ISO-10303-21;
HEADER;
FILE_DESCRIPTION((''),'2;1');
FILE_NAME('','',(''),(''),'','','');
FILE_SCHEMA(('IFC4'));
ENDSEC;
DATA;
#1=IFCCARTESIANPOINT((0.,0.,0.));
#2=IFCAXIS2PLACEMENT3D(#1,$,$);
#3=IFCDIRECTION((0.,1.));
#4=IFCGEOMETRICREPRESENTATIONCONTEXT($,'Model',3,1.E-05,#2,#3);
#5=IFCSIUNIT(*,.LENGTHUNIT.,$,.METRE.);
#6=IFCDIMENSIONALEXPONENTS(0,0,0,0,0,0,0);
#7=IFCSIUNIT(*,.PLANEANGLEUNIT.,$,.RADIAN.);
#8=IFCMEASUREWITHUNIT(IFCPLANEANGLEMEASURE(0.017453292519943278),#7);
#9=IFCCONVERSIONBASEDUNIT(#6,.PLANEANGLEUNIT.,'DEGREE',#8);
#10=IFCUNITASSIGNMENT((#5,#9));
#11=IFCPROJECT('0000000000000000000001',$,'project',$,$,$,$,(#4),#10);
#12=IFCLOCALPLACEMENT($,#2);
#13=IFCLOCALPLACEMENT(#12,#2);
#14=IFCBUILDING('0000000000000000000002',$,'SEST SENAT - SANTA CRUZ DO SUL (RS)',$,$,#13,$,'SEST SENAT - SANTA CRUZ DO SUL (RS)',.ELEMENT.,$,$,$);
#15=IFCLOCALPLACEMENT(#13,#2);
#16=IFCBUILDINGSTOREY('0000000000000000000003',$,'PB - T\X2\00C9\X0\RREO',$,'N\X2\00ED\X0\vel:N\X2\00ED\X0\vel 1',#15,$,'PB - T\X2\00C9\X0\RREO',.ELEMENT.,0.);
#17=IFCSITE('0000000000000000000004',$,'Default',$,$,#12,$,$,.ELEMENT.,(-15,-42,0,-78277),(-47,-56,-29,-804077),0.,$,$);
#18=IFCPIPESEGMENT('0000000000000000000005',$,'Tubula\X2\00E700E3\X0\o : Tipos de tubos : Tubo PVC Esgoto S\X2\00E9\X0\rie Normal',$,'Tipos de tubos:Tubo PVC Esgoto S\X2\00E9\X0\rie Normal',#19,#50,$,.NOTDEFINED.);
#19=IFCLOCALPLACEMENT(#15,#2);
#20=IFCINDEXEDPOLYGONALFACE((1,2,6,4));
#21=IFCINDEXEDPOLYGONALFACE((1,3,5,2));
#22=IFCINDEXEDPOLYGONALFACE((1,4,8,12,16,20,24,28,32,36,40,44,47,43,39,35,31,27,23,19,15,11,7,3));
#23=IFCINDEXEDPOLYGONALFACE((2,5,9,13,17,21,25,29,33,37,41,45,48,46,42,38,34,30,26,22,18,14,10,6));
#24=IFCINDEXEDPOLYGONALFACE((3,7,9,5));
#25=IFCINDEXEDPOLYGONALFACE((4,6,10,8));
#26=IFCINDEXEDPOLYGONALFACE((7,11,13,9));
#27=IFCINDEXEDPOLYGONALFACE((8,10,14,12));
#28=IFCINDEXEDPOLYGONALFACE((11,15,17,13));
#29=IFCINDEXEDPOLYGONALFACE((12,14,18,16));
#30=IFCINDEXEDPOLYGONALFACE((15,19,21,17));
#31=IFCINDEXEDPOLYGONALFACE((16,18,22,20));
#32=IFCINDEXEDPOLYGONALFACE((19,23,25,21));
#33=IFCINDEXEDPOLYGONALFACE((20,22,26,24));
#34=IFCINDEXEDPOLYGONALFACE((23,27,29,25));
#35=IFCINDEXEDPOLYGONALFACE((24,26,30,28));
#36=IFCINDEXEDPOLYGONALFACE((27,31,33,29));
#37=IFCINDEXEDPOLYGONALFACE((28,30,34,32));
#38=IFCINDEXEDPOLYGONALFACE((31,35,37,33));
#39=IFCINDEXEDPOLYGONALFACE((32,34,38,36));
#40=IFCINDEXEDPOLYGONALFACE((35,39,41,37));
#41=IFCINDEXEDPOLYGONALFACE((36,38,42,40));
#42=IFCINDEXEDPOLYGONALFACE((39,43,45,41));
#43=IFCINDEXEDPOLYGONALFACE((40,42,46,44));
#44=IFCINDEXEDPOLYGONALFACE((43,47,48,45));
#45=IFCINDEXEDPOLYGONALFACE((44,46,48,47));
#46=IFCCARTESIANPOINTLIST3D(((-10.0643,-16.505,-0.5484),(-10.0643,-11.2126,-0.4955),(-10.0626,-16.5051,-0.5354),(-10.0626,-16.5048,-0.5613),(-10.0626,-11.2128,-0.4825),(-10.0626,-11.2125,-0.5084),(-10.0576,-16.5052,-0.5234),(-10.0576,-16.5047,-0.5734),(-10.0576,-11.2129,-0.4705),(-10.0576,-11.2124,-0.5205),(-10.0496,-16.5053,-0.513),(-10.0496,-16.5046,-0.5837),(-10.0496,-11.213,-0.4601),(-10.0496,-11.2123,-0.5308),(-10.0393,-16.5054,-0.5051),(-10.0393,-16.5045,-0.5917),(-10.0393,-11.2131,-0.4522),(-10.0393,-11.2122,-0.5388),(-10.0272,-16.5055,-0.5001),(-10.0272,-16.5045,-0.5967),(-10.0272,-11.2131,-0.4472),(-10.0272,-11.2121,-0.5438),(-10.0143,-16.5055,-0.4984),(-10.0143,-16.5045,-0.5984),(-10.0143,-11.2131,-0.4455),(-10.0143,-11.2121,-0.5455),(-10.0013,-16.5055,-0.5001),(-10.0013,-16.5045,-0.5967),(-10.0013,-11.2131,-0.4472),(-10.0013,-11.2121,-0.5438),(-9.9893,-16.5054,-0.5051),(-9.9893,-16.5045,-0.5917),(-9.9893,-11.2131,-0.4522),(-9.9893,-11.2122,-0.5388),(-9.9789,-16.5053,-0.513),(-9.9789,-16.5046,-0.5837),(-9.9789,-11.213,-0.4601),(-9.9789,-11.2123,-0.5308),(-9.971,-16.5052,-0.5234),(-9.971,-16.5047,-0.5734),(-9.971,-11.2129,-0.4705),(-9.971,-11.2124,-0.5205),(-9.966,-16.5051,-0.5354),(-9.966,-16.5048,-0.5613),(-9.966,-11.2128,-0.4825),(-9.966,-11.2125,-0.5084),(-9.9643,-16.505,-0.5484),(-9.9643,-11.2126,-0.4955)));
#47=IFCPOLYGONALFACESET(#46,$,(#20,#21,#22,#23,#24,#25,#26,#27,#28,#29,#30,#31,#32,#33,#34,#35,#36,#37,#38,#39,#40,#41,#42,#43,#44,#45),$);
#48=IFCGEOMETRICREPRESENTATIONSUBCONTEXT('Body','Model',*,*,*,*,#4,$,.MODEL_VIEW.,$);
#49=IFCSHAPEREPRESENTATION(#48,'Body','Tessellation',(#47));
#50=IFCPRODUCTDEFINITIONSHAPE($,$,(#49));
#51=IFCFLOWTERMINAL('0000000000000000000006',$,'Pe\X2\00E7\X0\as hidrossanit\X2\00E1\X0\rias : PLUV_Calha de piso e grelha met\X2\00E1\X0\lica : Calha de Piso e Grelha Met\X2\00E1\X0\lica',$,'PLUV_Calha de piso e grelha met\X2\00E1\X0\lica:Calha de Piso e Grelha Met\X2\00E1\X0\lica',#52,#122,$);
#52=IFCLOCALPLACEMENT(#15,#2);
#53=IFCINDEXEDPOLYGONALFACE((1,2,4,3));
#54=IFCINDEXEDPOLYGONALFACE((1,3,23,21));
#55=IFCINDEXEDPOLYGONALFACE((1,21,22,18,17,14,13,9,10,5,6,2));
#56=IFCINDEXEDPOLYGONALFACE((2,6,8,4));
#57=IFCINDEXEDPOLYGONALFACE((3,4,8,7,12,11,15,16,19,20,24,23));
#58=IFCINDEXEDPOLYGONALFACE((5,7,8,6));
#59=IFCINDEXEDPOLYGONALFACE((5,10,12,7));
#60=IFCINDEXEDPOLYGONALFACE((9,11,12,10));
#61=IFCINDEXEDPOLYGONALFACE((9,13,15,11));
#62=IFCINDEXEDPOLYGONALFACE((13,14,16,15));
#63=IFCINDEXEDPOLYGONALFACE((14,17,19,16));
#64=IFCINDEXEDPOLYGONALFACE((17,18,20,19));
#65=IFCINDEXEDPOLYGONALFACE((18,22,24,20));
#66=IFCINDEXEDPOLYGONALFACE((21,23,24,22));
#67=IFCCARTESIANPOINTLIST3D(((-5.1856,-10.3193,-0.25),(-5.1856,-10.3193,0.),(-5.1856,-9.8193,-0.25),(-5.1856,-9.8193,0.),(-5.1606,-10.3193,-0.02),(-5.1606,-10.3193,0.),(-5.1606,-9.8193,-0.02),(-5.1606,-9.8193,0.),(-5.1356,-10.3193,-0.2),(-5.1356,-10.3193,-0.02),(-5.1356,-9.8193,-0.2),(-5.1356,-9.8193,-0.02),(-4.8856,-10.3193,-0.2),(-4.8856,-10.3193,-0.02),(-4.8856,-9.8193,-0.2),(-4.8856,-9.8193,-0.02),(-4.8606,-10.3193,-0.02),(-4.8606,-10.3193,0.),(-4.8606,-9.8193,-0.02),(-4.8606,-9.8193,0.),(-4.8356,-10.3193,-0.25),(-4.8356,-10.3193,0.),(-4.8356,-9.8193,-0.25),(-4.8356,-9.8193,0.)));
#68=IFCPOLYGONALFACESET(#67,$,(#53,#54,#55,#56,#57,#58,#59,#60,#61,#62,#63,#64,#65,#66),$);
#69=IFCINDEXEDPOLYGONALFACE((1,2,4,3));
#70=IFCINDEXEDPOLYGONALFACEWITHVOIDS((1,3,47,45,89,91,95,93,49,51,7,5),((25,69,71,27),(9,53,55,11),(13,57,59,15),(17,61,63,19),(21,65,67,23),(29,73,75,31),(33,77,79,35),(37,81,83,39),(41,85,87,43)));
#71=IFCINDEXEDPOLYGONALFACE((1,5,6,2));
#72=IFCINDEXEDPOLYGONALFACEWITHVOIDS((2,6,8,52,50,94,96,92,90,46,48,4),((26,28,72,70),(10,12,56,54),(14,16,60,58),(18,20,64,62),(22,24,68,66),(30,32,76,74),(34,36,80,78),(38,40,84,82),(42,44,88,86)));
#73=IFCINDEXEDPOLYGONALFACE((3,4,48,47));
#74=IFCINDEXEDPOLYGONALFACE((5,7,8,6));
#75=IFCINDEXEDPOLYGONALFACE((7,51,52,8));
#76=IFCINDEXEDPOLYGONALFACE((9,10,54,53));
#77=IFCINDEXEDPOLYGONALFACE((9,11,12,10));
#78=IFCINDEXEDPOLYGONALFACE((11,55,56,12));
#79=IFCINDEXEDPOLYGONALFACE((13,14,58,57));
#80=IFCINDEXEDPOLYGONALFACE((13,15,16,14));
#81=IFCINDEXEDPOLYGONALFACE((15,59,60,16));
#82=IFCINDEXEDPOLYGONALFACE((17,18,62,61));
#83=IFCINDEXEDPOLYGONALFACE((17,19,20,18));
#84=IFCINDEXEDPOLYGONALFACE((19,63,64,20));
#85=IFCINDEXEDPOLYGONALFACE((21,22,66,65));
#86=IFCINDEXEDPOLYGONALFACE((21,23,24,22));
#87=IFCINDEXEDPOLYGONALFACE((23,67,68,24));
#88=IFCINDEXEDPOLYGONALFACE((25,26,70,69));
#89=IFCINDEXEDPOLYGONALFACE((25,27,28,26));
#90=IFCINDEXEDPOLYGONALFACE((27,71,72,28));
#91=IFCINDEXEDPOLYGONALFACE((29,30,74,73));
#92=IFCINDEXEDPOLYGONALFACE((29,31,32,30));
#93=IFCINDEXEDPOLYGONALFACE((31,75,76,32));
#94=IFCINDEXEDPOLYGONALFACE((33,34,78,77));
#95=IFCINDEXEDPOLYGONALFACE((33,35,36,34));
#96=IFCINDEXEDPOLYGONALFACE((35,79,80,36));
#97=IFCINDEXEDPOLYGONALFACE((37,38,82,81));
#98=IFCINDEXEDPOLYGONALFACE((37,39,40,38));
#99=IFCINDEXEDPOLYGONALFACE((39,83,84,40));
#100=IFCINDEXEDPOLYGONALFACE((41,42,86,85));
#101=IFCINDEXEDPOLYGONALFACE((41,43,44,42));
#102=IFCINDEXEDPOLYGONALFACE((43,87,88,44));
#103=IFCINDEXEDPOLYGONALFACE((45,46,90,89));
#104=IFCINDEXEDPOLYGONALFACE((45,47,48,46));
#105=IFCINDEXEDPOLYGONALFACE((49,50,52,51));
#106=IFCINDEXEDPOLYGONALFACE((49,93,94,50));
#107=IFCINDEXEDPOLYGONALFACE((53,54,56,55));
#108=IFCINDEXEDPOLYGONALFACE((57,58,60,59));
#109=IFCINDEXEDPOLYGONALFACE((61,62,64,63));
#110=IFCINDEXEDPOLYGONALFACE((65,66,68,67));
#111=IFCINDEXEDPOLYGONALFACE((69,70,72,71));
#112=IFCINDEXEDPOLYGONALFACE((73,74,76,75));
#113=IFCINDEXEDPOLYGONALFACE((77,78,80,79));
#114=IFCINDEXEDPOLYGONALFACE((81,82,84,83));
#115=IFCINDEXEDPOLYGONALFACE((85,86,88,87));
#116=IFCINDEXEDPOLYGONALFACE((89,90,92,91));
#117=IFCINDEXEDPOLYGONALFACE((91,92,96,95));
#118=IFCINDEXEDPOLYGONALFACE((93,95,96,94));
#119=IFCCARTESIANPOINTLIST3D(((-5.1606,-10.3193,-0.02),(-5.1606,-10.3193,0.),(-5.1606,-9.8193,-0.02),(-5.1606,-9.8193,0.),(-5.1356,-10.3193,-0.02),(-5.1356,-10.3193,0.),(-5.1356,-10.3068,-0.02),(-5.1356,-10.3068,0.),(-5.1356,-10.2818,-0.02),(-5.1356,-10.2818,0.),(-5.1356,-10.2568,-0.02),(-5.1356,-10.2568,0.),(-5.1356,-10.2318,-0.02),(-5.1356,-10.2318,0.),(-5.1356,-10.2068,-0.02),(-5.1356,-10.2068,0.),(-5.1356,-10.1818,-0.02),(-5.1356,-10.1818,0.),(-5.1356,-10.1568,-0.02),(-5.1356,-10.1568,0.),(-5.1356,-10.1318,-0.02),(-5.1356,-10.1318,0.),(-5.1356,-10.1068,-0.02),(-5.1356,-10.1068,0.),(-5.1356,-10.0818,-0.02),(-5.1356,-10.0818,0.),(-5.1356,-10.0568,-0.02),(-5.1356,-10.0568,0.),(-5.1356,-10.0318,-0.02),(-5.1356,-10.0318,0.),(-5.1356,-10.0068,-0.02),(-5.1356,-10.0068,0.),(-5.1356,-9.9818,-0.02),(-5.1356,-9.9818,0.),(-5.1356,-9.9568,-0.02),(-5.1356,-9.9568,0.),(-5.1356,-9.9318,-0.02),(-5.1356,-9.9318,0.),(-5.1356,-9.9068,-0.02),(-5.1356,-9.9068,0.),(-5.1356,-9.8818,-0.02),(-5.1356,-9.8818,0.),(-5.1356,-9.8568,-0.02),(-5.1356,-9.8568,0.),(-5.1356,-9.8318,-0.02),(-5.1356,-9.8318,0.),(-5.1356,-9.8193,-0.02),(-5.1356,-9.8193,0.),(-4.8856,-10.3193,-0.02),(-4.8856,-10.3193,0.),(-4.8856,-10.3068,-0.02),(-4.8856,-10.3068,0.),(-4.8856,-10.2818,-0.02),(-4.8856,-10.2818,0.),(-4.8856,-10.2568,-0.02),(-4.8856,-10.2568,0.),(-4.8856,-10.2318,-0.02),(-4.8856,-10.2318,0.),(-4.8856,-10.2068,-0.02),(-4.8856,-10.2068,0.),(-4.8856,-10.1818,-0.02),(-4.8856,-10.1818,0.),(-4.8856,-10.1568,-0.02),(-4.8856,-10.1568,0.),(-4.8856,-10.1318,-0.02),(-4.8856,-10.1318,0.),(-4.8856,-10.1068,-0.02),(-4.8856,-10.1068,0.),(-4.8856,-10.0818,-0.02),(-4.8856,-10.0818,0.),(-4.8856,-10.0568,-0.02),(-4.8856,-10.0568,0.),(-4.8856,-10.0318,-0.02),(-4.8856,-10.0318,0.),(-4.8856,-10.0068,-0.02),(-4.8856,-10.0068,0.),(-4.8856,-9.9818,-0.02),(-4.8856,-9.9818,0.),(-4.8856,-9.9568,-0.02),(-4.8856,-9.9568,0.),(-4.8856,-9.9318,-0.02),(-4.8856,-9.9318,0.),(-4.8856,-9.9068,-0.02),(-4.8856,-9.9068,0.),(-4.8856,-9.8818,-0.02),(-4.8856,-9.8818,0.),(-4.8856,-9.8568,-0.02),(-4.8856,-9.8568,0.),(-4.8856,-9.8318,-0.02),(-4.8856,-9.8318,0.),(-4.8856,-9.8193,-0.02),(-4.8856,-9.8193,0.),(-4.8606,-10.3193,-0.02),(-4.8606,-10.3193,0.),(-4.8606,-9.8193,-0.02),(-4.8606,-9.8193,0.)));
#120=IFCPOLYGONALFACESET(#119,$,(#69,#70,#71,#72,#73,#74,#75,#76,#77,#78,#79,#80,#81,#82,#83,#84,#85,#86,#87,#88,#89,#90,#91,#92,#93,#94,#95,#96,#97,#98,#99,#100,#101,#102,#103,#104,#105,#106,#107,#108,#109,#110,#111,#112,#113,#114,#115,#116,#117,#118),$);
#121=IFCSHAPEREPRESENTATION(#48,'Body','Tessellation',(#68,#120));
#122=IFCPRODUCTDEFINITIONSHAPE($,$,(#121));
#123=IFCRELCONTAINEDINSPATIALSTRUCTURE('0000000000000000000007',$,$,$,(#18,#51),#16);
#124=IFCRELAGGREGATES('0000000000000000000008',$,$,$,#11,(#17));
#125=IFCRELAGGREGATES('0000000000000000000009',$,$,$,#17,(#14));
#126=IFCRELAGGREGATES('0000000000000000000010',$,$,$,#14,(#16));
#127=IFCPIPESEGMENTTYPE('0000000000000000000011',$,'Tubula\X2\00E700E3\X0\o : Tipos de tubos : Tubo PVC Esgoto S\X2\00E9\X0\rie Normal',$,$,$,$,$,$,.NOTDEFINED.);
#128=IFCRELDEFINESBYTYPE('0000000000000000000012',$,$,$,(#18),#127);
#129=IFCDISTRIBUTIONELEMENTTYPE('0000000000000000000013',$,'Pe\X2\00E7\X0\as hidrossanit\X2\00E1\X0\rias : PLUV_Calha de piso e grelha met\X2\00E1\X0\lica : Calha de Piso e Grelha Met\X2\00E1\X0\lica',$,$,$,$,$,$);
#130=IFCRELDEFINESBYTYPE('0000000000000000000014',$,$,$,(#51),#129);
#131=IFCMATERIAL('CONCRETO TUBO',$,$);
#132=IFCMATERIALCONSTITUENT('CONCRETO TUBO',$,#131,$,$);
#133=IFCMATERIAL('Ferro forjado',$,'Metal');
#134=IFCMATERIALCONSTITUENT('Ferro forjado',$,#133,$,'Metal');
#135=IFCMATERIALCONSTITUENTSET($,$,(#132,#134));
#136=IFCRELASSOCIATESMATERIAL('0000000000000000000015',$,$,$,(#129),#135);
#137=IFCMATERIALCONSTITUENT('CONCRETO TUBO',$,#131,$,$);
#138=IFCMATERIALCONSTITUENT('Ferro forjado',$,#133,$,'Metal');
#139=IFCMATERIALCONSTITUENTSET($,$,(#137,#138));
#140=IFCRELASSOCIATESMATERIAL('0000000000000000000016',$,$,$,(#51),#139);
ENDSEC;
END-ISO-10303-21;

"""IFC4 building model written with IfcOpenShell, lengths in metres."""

from ifc_helpers import new_model, entity, si_unit, converted_unit, direction, frame, origin, place, context, subcontext, project, spatial, arc, indexed_curve, outline, extrude, source, transform, mapped, material, constituent, constituent_set, type_object, type_shapes, element, save


model = new_model("IFC4")

# Units and contexts
model_context = context("Model", 3, precision=1e-05, world=origin(), true_north=direction((0.0, 1.0)))
body_context = subcontext(model_context, "Body", "Model", "MODEL_VIEW")
ifc_project = project(units=[si_unit("LENGTHUNIT", "METRE"), converted_unit("PLANEANGLEUNIT", "DEGREE", entity("IfcPlaneAngleMeasure", 0.017453292519943278), si_unit("PLANEANGLEUNIT", "RADIAN"), dimensions=[0, 0, 0, 0, 0, 0, 0])], contexts=[model_context])

# Site, building, storey
site_placement = place(None, origin())
site = spatial("IfcSite", under=ifc_project, at=site_placement, Name="Default", CompositionType="ELEMENT", RefLatitude=(-15, -42, 0, -78277), RefLongitude=(-47, -56, -29, -804077), RefElevation=0.0)
building_placement = place(site_placement, origin())
building = spatial("IfcBuilding", under=site, at=building_placement, Name="SEST SENAT - SANTA CRUZ DO SUL (RS)", LongName="SEST SENAT - SANTA CRUZ DO SUL (RS)", CompositionType="ELEMENT")
storey_placement = place(building_placement, origin())
storey = spatial("IfcBuildingStorey", under=building, at=storey_placement, Name="PB - TÉRREO", ObjectType="Nível:Nível 1", LongName="PB - TÉRREO", CompositionType="ELEMENT", Elevation=0.0)

# Pipe segment
pipe_segment_type_1 = type_object("IfcPipeSegmentType", Name="Tubulação : Tipos de tubos : Tubo PVC Esgoto Série Normal", PredefinedType="NOTDEFINED")
pipe_segment_1_placement = place(storey_placement, frame((-10.0659, -16.5071, -0.6)))
element("IfcPipeSegment", 1, at=pipe_segment_1_placement, inside=storey, type_object=pipe_segment_type_1, Name="Tubulação : Tipos de tubos : Tubo PVC Esgoto Série Normal", ObjectType="Tipos de tubos:Tubo PVC Esgoto Série Normal", PredefinedType="NOTDEFINED", context=body_context, shape_type="SweptSolid", body=[
    extrude(outline(indexed_curve([(0.05, 0.0), (0.0354, 0.0354), (0.0, 0.05), (-0.0354, 0.0354), (-0.05, 0.0), (-0.0354, -0.0354), (0.0, -0.05), (0.0354, -0.0354)], segments=[arc(1, 2, 3), arc(3, 4, 5), arc(5, 6, 7), arc(7, 8, 1)], self_intersect=False)), frame((0.0516, 0.0021, 0.0516), z_axis=(0.0, 0.99995, 0.01), x_axis=(-1.0, 0.0, 0.0)), (0.0, 0.0, 1.0), 5.2926),
])

# Flow terminal
ifc_material_1 = material(Name="CONCRETO TUBO")
ifc_constituent_1 = constituent(ifc_material_1, Name="CONCRETO TUBO")
ifc_material_2 = material(Name="Ferro forjado", Category="Metal")
ifc_constituent_2 = constituent(ifc_material_2, Name="Ferro forjado", Category="Metal")
ifc_constituent_set_1 = constituent_set(constituents=[ifc_constituent_1, ifc_constituent_2])
ifc_constituent_3 = constituent(ifc_material_1, Name="CONCRETO TUBO")
ifc_constituent_4 = constituent(ifc_material_2, Name="Ferro forjado", Category="Metal")
ifc_constituent_set_2 = constituent_set(constituents=[ifc_constituent_3, ifc_constituent_4])
distribution_element_type = type_object("IfcDistributionElementType", Name="Peças hidrossanitárias : PLUV_Calha de piso e grelha metálica : Calha de Piso e Grelha Metálica", material=ifc_constituent_set_2)
shared_shape_1 = source(origin(), body_context, "Body", "SweptSolid", [
    extrude(outline(indexed_curve([(-0.175, -0.0817), (-0.15, -0.0817), (-0.15, -0.0617), (-0.125, -0.0617), (-0.125, 0.1183), (0.125, 0.1183), (0.125, -0.0617), (0.15, -0.0617), (0.15, -0.0817), (0.175, -0.0817), (0.175, 0.1683), (-0.175, 0.1683), (-0.175, -0.0817)], self_intersect=False)), frame((-0.25, 0.0, -0.0817), z_axis=(1.0, 0.0, 0.0), x_axis=(0.0, -1.0, 0.0)), (0.0, 0.0, 1.0), 0.5),
    extrude(outline(indexed_curve([(0.125, -0.25), (0.15, -0.25), (0.15, 0.25), (0.125, 0.25), (0.125, 0.2375), (-0.125, 0.2375), (-0.125, 0.25), (-0.15, 0.25), (-0.15, -0.25), (-0.125, -0.25), (-0.125, -0.2375), (0.125, -0.2375), (0.125, -0.25)], self_intersect=False), holes=[indexed_curve([(0.125, 0.2125), (0.125, 0.1875), (-0.125, 0.1875), (-0.125, 0.2125), (0.125, 0.2125)], self_intersect=False), indexed_curve([(0.125, 0.1625), (0.125, 0.1375), (-0.125, 0.1375), (-0.125, 0.1625), (0.125, 0.1625)], self_intersect=False), indexed_curve([(0.125, 0.1125), (0.125, 0.0875), (-0.125, 0.0875), (-0.125, 0.1125), (0.125, 0.1125)], self_intersect=False), indexed_curve([(0.125, 0.0625), (0.125, 0.0375), (-0.125, 0.0375), (-0.125, 0.0625), (0.125, 0.0625)], self_intersect=False), indexed_curve([(0.125, 0.0125), (0.125, -0.0125), (-0.125, -0.0125), (-0.125, 0.0125), (0.125, 0.0125)], self_intersect=False), indexed_curve([(0.125, -0.0375), (0.125, -0.0625), (-0.125, -0.0625), (-0.125, -0.0375), (0.125, -0.0375)], self_intersect=False), indexed_curve([(0.125, -0.0875), (0.125, -0.1125), (-0.125, -0.1125), (-0.125, -0.0875), (0.125, -0.0875)], self_intersect=False), indexed_curve([(0.125, -0.1375), (0.125, -0.1625), (-0.125, -0.1625), (-0.125, -0.1375), (0.125, -0.1375)], self_intersect=False), indexed_curve([(0.125, -0.1875), (0.125, -0.2125), (-0.125, -0.2125), (-0.125, -0.1875), (0.125, -0.1875)], self_intersect=False)]), frame((0.0, 0.0, -0.02), z_axis=(0.0, 0.0, 1.0), x_axis=(0.0, 1.0, 0.0)), (0.0, 0.0, 1.0), 0.02),
])
type_shapes(distribution_element_type, [shared_shape_1])
flow_terminal_1_placement = place(storey_placement, frame((-5.0106, -10.0693, 0.0), z_axis=(0.0, 0.0, 1.0), x_axis=(0.0, 1.0, 0.0)))
element("IfcFlowTerminal", 2, at=flow_terminal_1_placement, inside=storey, type_object=distribution_element_type, material=ifc_constituent_set_1, Name="Peças hidrossanitárias : PLUV_Calha de piso e grelha metálica : Calha de Piso e Grelha Metálica", ObjectType="PLUV_Calha de piso e grelha metálica:Calha de Piso e Grelha Metálica", context=body_context, shape_type="MappedRepresentation", body=[
    mapped(shared_shape_1, transform((0.0, 0.0, 0.0), scale=1.0)),
])

save(model, "model.ifc")
